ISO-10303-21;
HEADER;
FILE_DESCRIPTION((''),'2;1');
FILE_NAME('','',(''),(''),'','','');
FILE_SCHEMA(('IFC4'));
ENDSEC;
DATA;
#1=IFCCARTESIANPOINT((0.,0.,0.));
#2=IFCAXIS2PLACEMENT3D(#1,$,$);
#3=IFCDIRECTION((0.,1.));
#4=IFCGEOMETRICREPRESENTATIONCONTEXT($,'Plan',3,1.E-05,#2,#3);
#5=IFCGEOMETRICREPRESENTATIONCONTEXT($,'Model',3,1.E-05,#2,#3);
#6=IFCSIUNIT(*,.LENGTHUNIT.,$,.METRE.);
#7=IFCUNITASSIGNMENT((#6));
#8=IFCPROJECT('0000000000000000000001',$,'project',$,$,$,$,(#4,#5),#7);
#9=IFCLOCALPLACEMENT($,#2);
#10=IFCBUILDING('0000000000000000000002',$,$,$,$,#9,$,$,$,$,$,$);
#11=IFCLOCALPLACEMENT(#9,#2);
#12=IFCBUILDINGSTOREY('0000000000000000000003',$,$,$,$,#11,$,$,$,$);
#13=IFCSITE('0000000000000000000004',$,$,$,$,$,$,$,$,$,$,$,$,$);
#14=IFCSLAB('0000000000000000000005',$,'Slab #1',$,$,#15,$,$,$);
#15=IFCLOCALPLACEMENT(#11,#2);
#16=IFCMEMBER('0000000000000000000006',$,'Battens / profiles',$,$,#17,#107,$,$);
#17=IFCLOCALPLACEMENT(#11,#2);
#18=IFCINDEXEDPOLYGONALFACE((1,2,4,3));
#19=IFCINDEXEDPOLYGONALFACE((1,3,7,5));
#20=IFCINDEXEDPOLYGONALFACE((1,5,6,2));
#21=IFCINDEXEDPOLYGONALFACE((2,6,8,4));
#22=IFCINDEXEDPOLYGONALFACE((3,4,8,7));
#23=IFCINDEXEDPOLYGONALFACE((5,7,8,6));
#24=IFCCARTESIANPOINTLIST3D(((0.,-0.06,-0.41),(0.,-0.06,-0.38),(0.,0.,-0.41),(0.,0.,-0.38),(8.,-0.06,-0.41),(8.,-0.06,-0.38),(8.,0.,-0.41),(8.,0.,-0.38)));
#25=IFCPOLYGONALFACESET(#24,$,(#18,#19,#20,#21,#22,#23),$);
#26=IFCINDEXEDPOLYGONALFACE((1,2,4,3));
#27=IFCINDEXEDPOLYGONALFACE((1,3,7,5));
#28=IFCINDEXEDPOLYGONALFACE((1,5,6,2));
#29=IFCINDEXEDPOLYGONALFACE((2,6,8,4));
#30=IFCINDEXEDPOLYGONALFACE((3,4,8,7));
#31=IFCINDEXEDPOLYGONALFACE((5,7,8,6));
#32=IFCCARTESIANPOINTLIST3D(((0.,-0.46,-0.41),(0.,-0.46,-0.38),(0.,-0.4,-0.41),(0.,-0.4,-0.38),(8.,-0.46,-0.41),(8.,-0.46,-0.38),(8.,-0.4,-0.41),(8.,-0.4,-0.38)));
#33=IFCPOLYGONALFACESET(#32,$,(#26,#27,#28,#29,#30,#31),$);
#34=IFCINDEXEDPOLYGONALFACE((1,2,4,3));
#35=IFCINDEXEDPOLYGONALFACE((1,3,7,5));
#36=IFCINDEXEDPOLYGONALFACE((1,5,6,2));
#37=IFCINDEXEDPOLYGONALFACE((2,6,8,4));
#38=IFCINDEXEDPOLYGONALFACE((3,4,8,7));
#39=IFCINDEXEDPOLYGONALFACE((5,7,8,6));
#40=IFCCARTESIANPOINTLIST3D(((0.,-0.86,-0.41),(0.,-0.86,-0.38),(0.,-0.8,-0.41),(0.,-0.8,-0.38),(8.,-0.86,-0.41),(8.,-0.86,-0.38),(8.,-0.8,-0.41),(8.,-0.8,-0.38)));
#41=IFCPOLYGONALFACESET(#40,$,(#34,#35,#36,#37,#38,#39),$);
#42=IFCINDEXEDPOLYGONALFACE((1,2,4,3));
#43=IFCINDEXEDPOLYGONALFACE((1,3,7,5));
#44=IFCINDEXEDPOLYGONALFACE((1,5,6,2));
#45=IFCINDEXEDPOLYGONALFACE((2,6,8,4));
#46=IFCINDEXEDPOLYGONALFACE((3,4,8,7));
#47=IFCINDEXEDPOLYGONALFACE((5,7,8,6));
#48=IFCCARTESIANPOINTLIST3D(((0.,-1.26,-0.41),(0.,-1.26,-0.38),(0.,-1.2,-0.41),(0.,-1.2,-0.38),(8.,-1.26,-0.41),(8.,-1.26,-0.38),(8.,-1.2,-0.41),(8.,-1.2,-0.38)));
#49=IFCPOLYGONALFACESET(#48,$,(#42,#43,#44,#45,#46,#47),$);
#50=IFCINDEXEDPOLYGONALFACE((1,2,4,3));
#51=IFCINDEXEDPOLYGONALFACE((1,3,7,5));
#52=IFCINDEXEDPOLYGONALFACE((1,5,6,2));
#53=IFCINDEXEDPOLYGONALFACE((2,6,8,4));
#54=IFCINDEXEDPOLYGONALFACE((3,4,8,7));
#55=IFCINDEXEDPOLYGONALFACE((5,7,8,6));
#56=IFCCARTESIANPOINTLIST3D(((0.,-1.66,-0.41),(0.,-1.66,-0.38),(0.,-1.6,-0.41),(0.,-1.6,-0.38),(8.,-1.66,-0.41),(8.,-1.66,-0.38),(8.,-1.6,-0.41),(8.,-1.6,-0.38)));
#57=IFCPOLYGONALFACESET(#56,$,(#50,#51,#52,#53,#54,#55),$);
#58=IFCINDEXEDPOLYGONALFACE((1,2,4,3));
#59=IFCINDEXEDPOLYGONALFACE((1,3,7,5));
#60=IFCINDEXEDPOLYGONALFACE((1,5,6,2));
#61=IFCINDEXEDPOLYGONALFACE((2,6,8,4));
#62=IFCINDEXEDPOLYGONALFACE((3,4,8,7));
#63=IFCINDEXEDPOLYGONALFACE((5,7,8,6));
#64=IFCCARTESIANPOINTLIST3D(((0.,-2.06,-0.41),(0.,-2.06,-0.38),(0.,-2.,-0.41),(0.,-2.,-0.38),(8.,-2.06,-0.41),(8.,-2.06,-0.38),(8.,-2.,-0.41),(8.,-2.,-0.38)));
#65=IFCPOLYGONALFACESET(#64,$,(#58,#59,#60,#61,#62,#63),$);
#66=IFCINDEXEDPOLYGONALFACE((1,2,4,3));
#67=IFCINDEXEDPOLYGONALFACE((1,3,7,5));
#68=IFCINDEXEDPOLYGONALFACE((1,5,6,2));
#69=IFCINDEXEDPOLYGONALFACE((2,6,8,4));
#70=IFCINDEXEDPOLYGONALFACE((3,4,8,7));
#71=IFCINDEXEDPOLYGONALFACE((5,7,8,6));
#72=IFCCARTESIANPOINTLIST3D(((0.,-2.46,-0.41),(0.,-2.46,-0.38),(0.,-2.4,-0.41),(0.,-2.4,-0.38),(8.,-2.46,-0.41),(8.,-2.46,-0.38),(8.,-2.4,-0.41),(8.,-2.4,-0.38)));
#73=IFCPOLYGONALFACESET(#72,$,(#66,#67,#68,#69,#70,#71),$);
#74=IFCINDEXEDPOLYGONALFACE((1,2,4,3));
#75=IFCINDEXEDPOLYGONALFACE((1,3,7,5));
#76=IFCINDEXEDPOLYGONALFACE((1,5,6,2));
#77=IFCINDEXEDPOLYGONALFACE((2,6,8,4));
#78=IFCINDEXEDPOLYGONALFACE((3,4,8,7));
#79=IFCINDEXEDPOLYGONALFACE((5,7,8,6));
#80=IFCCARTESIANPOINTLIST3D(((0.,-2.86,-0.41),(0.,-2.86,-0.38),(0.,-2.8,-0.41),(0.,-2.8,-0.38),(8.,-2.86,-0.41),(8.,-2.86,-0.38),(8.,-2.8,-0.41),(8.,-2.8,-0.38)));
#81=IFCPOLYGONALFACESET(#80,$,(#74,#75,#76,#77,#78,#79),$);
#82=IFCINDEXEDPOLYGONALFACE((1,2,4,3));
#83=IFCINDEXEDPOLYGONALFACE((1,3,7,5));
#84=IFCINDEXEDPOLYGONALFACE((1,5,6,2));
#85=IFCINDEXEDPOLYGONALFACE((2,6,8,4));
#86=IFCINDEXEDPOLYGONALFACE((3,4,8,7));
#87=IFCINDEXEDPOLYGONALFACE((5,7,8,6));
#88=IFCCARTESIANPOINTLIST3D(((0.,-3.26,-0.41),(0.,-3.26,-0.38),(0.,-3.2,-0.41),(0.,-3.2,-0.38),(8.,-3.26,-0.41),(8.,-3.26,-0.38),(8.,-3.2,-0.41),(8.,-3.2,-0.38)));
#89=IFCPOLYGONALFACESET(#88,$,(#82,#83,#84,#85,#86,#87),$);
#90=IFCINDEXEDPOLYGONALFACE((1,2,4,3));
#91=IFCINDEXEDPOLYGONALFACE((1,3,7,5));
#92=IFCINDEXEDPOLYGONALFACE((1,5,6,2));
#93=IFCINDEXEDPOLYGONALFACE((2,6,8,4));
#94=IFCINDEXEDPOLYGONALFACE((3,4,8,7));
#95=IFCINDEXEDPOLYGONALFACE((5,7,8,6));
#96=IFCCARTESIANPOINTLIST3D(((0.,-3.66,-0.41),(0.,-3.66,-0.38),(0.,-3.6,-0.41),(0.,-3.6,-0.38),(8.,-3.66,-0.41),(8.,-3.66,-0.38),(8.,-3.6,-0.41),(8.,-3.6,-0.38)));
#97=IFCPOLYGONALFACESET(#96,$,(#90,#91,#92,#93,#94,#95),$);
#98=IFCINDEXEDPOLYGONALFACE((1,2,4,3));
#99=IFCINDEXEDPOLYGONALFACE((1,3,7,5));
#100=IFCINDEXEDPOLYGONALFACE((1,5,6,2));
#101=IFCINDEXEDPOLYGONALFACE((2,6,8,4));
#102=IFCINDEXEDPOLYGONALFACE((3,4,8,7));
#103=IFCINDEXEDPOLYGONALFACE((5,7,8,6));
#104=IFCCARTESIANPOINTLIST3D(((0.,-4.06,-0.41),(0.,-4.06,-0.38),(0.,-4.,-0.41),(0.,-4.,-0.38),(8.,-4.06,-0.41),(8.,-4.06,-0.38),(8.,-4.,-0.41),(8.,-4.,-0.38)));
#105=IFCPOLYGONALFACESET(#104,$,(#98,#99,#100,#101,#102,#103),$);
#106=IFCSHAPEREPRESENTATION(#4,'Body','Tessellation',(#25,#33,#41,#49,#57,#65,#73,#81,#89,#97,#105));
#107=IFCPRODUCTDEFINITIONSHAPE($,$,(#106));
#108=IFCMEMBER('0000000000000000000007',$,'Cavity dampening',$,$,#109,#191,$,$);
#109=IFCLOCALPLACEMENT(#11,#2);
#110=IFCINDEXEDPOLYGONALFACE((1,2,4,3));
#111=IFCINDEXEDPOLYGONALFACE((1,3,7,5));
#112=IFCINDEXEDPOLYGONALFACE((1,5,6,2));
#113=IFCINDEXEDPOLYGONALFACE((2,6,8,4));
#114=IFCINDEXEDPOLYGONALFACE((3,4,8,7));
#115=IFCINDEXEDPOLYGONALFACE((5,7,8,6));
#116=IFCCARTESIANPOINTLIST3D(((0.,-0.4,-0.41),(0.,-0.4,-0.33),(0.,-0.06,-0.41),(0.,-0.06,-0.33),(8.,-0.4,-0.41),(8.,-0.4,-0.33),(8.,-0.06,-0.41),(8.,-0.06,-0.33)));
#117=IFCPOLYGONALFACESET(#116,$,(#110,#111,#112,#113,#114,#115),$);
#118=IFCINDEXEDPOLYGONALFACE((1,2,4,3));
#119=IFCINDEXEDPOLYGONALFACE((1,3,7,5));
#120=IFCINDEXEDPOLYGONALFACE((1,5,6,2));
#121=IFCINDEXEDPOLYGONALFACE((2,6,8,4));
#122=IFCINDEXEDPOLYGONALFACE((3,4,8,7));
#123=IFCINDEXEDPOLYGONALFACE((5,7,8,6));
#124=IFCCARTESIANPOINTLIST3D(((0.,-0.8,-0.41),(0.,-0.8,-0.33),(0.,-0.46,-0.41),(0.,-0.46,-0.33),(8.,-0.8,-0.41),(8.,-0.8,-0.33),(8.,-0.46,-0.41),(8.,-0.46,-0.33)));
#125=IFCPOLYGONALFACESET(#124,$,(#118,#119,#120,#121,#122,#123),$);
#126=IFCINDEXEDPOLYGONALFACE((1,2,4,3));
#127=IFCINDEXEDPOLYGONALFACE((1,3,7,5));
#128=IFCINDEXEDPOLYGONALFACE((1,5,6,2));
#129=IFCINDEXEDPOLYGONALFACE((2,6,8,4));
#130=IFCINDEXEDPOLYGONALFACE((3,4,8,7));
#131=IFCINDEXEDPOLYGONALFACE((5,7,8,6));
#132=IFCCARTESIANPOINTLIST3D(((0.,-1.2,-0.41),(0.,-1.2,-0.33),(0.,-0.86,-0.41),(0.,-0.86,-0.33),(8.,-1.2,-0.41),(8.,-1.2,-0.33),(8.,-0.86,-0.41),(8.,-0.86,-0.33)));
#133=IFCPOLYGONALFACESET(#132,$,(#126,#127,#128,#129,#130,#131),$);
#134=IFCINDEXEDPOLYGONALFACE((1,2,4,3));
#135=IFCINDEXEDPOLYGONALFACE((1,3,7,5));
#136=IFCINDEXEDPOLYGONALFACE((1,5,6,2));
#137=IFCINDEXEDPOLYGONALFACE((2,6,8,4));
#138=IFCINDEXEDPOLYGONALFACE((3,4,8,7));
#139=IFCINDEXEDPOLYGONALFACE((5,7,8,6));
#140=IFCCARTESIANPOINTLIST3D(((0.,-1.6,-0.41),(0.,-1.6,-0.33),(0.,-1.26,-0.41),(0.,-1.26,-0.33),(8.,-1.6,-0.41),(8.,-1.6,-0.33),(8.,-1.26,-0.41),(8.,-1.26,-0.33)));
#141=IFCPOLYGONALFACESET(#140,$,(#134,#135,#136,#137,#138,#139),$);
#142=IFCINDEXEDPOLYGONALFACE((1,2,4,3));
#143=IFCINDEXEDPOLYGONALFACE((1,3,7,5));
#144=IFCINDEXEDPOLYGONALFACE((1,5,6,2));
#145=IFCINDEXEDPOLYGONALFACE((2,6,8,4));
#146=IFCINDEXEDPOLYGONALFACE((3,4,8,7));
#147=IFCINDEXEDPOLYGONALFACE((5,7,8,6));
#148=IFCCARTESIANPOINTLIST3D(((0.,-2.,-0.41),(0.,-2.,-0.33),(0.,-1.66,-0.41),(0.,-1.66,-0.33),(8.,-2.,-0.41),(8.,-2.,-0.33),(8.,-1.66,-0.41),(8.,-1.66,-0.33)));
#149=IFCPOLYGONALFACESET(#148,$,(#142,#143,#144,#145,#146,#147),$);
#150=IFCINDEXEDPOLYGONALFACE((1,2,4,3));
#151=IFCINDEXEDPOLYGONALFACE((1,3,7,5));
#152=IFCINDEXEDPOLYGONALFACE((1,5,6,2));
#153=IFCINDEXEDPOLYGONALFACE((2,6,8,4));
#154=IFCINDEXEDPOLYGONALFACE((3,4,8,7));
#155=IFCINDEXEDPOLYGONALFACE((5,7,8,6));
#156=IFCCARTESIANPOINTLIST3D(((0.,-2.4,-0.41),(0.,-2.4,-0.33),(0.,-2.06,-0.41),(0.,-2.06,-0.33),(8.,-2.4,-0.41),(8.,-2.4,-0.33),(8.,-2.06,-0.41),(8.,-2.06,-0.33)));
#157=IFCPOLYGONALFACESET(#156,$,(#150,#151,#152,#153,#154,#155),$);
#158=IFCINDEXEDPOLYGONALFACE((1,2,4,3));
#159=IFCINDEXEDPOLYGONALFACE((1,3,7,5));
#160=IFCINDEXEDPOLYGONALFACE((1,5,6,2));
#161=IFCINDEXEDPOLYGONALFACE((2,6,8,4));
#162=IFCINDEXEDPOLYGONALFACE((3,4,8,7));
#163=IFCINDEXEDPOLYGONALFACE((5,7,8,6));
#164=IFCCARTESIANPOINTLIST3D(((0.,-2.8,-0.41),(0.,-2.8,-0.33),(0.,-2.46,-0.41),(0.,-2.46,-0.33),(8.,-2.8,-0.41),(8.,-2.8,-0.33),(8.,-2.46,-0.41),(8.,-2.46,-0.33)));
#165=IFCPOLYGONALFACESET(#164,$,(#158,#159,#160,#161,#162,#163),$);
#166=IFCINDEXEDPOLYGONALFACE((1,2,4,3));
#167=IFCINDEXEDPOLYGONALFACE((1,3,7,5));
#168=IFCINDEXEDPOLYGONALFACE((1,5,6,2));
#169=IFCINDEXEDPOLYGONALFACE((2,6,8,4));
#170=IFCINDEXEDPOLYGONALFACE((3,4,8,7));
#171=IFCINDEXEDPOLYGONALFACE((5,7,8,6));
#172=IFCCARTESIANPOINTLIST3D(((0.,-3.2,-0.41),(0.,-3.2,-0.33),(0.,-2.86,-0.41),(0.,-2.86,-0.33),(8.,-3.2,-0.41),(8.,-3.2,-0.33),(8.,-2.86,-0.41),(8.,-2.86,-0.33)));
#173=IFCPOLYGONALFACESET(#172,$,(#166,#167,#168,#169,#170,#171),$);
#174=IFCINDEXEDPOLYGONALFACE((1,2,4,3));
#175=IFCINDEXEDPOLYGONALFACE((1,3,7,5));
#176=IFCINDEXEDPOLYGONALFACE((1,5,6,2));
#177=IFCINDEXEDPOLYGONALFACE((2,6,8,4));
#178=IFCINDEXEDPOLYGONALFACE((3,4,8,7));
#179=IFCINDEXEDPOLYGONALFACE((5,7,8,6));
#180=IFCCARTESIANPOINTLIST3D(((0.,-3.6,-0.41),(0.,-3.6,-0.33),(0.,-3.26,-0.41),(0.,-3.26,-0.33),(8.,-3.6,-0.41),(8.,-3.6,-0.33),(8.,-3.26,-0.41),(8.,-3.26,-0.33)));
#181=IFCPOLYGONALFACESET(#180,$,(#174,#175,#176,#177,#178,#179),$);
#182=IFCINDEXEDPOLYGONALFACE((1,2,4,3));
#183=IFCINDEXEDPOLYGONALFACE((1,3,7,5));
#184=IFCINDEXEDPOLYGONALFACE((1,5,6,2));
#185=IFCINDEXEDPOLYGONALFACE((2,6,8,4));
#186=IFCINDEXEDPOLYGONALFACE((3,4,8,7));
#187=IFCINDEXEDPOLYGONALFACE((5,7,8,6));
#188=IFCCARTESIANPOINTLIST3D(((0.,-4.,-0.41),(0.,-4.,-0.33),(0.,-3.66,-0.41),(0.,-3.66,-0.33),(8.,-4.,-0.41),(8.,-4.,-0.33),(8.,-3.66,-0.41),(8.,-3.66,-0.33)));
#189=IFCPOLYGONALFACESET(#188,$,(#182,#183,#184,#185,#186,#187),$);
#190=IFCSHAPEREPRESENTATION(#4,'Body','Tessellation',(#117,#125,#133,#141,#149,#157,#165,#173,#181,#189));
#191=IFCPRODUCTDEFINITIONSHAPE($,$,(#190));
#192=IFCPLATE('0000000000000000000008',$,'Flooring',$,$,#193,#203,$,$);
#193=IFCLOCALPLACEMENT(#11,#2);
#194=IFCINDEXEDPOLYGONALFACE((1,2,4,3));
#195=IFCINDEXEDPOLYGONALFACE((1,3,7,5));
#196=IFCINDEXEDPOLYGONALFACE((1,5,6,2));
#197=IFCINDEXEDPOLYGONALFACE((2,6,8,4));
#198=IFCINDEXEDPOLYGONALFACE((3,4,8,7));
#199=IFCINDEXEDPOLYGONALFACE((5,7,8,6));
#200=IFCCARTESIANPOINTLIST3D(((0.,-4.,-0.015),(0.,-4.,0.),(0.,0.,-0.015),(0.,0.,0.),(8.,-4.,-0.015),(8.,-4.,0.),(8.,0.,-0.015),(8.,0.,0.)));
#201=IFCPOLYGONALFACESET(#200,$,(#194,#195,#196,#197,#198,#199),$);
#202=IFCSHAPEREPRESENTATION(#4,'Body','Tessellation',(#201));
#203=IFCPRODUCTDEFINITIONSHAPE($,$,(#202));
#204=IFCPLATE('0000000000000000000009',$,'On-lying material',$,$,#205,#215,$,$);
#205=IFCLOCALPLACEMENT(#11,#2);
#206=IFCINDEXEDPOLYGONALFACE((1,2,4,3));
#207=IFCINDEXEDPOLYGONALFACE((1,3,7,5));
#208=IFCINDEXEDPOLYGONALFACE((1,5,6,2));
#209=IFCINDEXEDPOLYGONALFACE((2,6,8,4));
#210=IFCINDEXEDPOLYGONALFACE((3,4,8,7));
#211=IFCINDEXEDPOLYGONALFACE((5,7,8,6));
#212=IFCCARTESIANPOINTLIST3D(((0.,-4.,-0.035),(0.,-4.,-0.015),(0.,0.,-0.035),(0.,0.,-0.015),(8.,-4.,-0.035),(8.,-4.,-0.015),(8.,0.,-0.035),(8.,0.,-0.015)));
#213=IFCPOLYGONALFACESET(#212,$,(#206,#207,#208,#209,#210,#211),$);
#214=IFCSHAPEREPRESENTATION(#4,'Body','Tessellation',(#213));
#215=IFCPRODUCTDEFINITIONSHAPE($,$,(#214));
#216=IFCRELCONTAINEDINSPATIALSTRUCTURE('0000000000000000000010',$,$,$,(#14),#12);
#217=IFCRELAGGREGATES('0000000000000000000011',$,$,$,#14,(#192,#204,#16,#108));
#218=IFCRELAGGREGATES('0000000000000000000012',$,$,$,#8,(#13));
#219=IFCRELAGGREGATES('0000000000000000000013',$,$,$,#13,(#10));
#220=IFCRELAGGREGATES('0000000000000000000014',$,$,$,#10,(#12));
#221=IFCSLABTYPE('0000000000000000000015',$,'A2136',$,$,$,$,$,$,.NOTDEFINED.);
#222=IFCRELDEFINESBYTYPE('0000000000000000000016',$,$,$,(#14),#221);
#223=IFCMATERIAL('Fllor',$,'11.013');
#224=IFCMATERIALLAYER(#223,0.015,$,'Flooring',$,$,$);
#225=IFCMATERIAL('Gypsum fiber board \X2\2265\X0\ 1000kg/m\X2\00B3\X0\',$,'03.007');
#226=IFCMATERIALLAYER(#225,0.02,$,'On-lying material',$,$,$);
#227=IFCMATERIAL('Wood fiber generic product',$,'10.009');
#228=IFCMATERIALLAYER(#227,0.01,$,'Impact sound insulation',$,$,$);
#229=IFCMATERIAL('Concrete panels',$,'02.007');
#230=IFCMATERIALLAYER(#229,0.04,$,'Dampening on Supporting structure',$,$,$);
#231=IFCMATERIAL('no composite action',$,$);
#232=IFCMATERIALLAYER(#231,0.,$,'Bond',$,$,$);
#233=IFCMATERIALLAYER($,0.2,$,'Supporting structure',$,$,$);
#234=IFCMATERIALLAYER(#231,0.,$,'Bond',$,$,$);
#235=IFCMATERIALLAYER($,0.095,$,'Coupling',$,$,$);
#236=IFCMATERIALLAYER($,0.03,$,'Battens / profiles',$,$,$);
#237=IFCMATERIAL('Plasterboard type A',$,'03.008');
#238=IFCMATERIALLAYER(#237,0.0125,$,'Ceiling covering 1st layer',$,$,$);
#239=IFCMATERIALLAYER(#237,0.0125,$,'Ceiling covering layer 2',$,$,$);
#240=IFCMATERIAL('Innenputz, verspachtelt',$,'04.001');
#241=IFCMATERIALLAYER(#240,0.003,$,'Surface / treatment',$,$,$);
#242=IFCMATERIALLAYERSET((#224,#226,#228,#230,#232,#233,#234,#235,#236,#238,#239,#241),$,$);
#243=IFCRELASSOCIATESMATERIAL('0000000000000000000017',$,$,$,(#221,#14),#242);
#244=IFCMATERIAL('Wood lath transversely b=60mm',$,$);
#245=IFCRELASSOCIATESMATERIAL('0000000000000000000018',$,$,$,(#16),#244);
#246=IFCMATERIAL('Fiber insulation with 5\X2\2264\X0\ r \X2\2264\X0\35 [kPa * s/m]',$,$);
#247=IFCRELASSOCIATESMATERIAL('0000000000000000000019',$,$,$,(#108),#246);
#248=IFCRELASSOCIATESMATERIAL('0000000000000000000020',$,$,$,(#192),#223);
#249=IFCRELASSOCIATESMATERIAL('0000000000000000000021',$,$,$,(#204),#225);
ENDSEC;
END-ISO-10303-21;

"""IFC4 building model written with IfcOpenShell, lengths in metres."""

from ifc_helpers import new_model, si_unit, direction, frame, frame_2d, origin, origin_with_axes, place, context, project, spatial, rectangle, extrude, material, layer, layer_set, type_object, element, aggregate, save


model = new_model("IFC4")

# Units and contexts
plan_context = context("Plan", 3, precision=1e-05, world=origin(), true_north=direction((0.0, 1.0)))
model_context = context("Model", 3, precision=1e-05, world=origin(), true_north=direction((0.0, 1.0)))
ifc_project = project(units=[si_unit("LENGTHUNIT", "METRE")], contexts=[plan_context, model_context])

# Site, building, storey
site = spatial("IfcSite", under=ifc_project)
building_placement = place(None, origin())
building = spatial("IfcBuilding", under=site, at=building_placement)
storey_placement = place(building_placement, origin())
storey = spatial("IfcBuildingStorey", under=building, at=storey_placement)

# Slab, members, plates
ifc_material_1 = material(Name="Fllor", Category="11.013")
ifc_layer_1 = layer(ifc_material_1, 0.015, Name="Flooring")
ifc_material_2 = material(Name="Gypsum fiber board ≥ 1000kg/m³", Category="03.007")
ifc_layer_2 = layer(ifc_material_2, 0.02, Name="On-lying material")
ifc_material_3 = material(Name="Wood fiber generic product", Category="10.009")
ifc_layer_3 = layer(ifc_material_3, 0.01, Name="Impact sound insulation")
ifc_material_4 = material(Name="Concrete panels", Category="02.007")
ifc_layer_4 = layer(ifc_material_4, 0.04, Name="Dampening on Supporting structure")
ifc_material_5 = material(Name="no composite action")
ifc_layer_5 = layer(ifc_material_5, 0.0, Name="Bond")
ifc_layer_6 = layer(None, 0.2, Name="Supporting structure")
ifc_layer_7 = layer(ifc_material_5, 0.0, Name="Bond")
ifc_layer_8 = layer(None, 0.095, Name="Coupling")
ifc_layer_9 = layer(None, 0.03, Name="Battens / profiles")
ifc_material_6 = material(Name="Plasterboard type A", Category="03.008")
ifc_layer_10 = layer(ifc_material_6, 0.0125, Name="Ceiling covering 1st layer")
ifc_layer_11 = layer(ifc_material_6, 0.0125, Name="Ceiling covering layer 2")
ifc_material_7 = material(Name="Innenputz, verspachtelt", Category="04.001")
ifc_layer_12 = layer(ifc_material_7, 0.003, Name="Surface / treatment")
ifc_layer_set = layer_set([ifc_layer_1, ifc_layer_2, ifc_layer_3, ifc_layer_4, ifc_layer_5, ifc_layer_6, ifc_layer_7, ifc_layer_8, ifc_layer_9, ifc_layer_10, ifc_layer_11, ifc_layer_12])
slab_type = type_object("IfcSlabType", Name="A2136", PredefinedType="NOTDEFINED", material=ifc_layer_set)
slab_placement = place(None, frame((0.0, 0.0, 0.0), z_axis=(0.0, 0.0, -1.0), x_axis=(1.0, 0.0, 0.0)))
slab = element("IfcSlab", 1, at=slab_placement, inside=storey, type_object=slab_type, material=ifc_layer_set, Name="Slab #1")
ifc_material_8 = material(Name="Wood lath transversely b=60mm")
member_1_placement = place(slab_placement, origin())
member_1 = element("IfcMember", 2, at=member_1_placement, material=ifc_material_8, Name="Battens / profiles", context=plan_context, shape_type="SweptSolid", body=[
    extrude(rectangle(XDim=0.06, YDim=0.03, at=frame_2d((0.03, 0.015), x_axis=(1.0, 0.0))), frame((0.0, 0.0, 0.38), z_axis=(1.0, 0.0, 0.0), x_axis=(0.0, 1.0, 0.0)), (0.0, 0.0, 1.0), 8.0),
    extrude(rectangle(XDim=0.06, YDim=0.03, at=frame_2d((0.03, 0.015), x_axis=(1.0, 0.0))), frame((0.0, 0.4, 0.38), z_axis=(1.0, 0.0, 0.0), x_axis=(0.0, 1.0, 0.0)), (0.0, 0.0, 1.0), 8.0),
    extrude(rectangle(XDim=0.06, YDim=0.03, at=frame_2d((0.03, 0.015), x_axis=(1.0, 0.0))), frame((0.0, 0.8, 0.38), z_axis=(1.0, 0.0, 0.0), x_axis=(0.0, 1.0, 0.0)), (0.0, 0.0, 1.0), 8.0),
    extrude(rectangle(XDim=0.06, YDim=0.03, at=frame_2d((0.03, 0.015), x_axis=(1.0, 0.0))), frame((0.0, 1.2, 0.38), z_axis=(1.0, 0.0, 0.0), x_axis=(0.0, 1.0, 0.0)), (0.0, 0.0, 1.0), 8.0),
    extrude(rectangle(XDim=0.06, YDim=0.03, at=frame_2d((0.03, 0.015), x_axis=(1.0, 0.0))), frame((0.0, 1.6, 0.38), z_axis=(1.0, 0.0, 0.0), x_axis=(0.0, 1.0, 0.0)), (0.0, 0.0, 1.0), 8.0),
    extrude(rectangle(XDim=0.06, YDim=0.03, at=frame_2d((0.03, 0.015), x_axis=(1.0, 0.0))), frame((0.0, 2.0, 0.38), z_axis=(1.0, 0.0, 0.0), x_axis=(0.0, 1.0, 0.0)), (0.0, 0.0, 1.0), 8.0),
    extrude(rectangle(XDim=0.06, YDim=0.03, at=frame_2d((0.03, 0.015), x_axis=(1.0, 0.0))), frame((0.0, 2.4, 0.38), z_axis=(1.0, 0.0, 0.0), x_axis=(0.0, 1.0, 0.0)), (0.0, 0.0, 1.0), 8.0),
    extrude(rectangle(XDim=0.06, YDim=0.03, at=frame_2d((0.03, 0.015), x_axis=(1.0, 0.0))), frame((0.0, 2.8, 0.38), z_axis=(1.0, 0.0, 0.0), x_axis=(0.0, 1.0, 0.0)), (0.0, 0.0, 1.0), 8.0),
    extrude(rectangle(XDim=0.06, YDim=0.03, at=frame_2d((0.03, 0.015), x_axis=(1.0, 0.0))), frame((0.0, 3.2, 0.38), z_axis=(1.0, 0.0, 0.0), x_axis=(0.0, 1.0, 0.0)), (0.0, 0.0, 1.0), 8.0),
    extrude(rectangle(XDim=0.06, YDim=0.03, at=frame_2d((0.03, 0.015), x_axis=(1.0, 0.0))), frame((0.0, 3.6, 0.38), z_axis=(1.0, 0.0, 0.0), x_axis=(0.0, 1.0, 0.0)), (0.0, 0.0, 1.0), 8.0),
    extrude(rectangle(XDim=0.06, YDim=0.03, at=frame_2d((0.03, 0.015), x_axis=(1.0, 0.0))), frame((0.0, 4.0, 0.38), z_axis=(1.0, 0.0, 0.0), x_axis=(0.0, 1.0, 0.0)), (0.0, 0.0, 1.0), 8.0),
])
ifc_material_9 = material(Name="Fiber insulation with 5≤ r ≤35 [kPa * s/m]")
member_2_placement = place(slab_placement, origin())
member_2 = element("IfcMember", 3, at=member_2_placement, material=ifc_material_9, Name="Cavity dampening", context=plan_context, shape_type="SweptSolid", body=[
    extrude(rectangle(XDim=0.34, YDim=0.08, at=frame_2d((0.17, 0.04), x_axis=(1.0, 0.0))), frame((0.0, 0.06, 0.33), z_axis=(1.0, 0.0, 0.0), x_axis=(0.0, 1.0, 0.0)), (0.0, 0.0, 1.0), 8.0),
    extrude(rectangle(XDim=0.34, YDim=0.08, at=frame_2d((0.17, 0.04), x_axis=(1.0, 0.0))), frame((0.0, 0.46, 0.33), z_axis=(1.0, 0.0, 0.0), x_axis=(0.0, 1.0, 0.0)), (0.0, 0.0, 1.0), 8.0),
    extrude(rectangle(XDim=0.34, YDim=0.08, at=frame_2d((0.17, 0.04), x_axis=(1.0, 0.0))), frame((0.0, 0.86, 0.33), z_axis=(1.0, 0.0, 0.0), x_axis=(0.0, 1.0, 0.0)), (0.0, 0.0, 1.0), 8.0),
    extrude(rectangle(XDim=0.34, YDim=0.08, at=frame_2d((0.17, 0.04), x_axis=(1.0, 0.0))), frame((0.0, 1.26, 0.33), z_axis=(1.0, 0.0, 0.0), x_axis=(0.0, 1.0, 0.0)), (0.0, 0.0, 1.0), 8.0),
    extrude(rectangle(XDim=0.34, YDim=0.08, at=frame_2d((0.17, 0.04), x_axis=(1.0, 0.0))), frame((0.0, 1.66, 0.33), z_axis=(1.0, 0.0, 0.0), x_axis=(0.0, 1.0, 0.0)), (0.0, 0.0, 1.0), 8.0),
    extrude(rectangle(XDim=0.34, YDim=0.08, at=frame_2d((0.17, 0.04), x_axis=(1.0, 0.0))), frame((0.0, 2.06, 0.33), z_axis=(1.0, 0.0, 0.0), x_axis=(0.0, 1.0, 0.0)), (0.0, 0.0, 1.0), 8.0),
    extrude(rectangle(XDim=0.34, YDim=0.08, at=frame_2d((0.17, 0.04), x_axis=(1.0, 0.0))), frame((0.0, 2.46, 0.33), z_axis=(1.0, 0.0, 0.0), x_axis=(0.0, 1.0, 0.0)), (0.0, 0.0, 1.0), 8.0),
    extrude(rectangle(XDim=0.34, YDim=0.08, at=frame_2d((0.17, 0.04), x_axis=(1.0, 0.0))), frame((0.0, 2.86, 0.33), z_axis=(1.0, 0.0, 0.0), x_axis=(0.0, 1.0, 0.0)), (0.0, 0.0, 1.0), 8.0),
    extrude(rectangle(XDim=0.34, YDim=0.08, at=frame_2d((0.17, 0.04), x_axis=(1.0, 0.0))), frame((0.0, 3.26, 0.33), z_axis=(1.0, 0.0, 0.0), x_axis=(0.0, 1.0, 0.0)), (0.0, 0.0, 1.0), 8.0),
    extrude(rectangle(XDim=0.34, YDim=0.08, at=frame_2d((0.17, 0.04), x_axis=(1.0, 0.0))), frame((0.0, 3.66, 0.33), z_axis=(1.0, 0.0, 0.0), x_axis=(0.0, 1.0, 0.0)), (0.0, 0.0, 1.0), 8.0),
])
plate_1_placement = place(slab_placement, origin())
plate_1 = element("IfcPlate", 4, at=plate_1_placement, material=ifc_material_1, Name="Flooring", context=plan_context, shape_type="SweptSolid", body=[
    extrude(rectangle(XDim=8.0, YDim=4.0, at=frame_2d((4.0, 2.0), x_axis=(1.0, 0.0))), origin_with_axes(), (0.0, 0.0, 1.0), 0.015),
])
plate_2_placement = place(slab_placement, origin())
plate_2 = element("IfcPlate", 5, at=plate_2_placement, material=ifc_material_2, Name="On-lying material", context=plan_context, shape_type="SweptSolid", body=[
    extrude(rectangle(XDim=8.0, YDim=4.0, at=frame_2d((4.0, 2.0), x_axis=(1.0, 0.0))), frame((0.0, 0.0, 0.015), z_axis=(0.0, 0.0, 1.0), x_axis=(1.0, 0.0, 0.0)), (0.0, 0.0, 1.0), 0.02),
])
aggregate(slab, [plate_1, plate_2, member_1, member_2])

save(model, "model.ifc")
